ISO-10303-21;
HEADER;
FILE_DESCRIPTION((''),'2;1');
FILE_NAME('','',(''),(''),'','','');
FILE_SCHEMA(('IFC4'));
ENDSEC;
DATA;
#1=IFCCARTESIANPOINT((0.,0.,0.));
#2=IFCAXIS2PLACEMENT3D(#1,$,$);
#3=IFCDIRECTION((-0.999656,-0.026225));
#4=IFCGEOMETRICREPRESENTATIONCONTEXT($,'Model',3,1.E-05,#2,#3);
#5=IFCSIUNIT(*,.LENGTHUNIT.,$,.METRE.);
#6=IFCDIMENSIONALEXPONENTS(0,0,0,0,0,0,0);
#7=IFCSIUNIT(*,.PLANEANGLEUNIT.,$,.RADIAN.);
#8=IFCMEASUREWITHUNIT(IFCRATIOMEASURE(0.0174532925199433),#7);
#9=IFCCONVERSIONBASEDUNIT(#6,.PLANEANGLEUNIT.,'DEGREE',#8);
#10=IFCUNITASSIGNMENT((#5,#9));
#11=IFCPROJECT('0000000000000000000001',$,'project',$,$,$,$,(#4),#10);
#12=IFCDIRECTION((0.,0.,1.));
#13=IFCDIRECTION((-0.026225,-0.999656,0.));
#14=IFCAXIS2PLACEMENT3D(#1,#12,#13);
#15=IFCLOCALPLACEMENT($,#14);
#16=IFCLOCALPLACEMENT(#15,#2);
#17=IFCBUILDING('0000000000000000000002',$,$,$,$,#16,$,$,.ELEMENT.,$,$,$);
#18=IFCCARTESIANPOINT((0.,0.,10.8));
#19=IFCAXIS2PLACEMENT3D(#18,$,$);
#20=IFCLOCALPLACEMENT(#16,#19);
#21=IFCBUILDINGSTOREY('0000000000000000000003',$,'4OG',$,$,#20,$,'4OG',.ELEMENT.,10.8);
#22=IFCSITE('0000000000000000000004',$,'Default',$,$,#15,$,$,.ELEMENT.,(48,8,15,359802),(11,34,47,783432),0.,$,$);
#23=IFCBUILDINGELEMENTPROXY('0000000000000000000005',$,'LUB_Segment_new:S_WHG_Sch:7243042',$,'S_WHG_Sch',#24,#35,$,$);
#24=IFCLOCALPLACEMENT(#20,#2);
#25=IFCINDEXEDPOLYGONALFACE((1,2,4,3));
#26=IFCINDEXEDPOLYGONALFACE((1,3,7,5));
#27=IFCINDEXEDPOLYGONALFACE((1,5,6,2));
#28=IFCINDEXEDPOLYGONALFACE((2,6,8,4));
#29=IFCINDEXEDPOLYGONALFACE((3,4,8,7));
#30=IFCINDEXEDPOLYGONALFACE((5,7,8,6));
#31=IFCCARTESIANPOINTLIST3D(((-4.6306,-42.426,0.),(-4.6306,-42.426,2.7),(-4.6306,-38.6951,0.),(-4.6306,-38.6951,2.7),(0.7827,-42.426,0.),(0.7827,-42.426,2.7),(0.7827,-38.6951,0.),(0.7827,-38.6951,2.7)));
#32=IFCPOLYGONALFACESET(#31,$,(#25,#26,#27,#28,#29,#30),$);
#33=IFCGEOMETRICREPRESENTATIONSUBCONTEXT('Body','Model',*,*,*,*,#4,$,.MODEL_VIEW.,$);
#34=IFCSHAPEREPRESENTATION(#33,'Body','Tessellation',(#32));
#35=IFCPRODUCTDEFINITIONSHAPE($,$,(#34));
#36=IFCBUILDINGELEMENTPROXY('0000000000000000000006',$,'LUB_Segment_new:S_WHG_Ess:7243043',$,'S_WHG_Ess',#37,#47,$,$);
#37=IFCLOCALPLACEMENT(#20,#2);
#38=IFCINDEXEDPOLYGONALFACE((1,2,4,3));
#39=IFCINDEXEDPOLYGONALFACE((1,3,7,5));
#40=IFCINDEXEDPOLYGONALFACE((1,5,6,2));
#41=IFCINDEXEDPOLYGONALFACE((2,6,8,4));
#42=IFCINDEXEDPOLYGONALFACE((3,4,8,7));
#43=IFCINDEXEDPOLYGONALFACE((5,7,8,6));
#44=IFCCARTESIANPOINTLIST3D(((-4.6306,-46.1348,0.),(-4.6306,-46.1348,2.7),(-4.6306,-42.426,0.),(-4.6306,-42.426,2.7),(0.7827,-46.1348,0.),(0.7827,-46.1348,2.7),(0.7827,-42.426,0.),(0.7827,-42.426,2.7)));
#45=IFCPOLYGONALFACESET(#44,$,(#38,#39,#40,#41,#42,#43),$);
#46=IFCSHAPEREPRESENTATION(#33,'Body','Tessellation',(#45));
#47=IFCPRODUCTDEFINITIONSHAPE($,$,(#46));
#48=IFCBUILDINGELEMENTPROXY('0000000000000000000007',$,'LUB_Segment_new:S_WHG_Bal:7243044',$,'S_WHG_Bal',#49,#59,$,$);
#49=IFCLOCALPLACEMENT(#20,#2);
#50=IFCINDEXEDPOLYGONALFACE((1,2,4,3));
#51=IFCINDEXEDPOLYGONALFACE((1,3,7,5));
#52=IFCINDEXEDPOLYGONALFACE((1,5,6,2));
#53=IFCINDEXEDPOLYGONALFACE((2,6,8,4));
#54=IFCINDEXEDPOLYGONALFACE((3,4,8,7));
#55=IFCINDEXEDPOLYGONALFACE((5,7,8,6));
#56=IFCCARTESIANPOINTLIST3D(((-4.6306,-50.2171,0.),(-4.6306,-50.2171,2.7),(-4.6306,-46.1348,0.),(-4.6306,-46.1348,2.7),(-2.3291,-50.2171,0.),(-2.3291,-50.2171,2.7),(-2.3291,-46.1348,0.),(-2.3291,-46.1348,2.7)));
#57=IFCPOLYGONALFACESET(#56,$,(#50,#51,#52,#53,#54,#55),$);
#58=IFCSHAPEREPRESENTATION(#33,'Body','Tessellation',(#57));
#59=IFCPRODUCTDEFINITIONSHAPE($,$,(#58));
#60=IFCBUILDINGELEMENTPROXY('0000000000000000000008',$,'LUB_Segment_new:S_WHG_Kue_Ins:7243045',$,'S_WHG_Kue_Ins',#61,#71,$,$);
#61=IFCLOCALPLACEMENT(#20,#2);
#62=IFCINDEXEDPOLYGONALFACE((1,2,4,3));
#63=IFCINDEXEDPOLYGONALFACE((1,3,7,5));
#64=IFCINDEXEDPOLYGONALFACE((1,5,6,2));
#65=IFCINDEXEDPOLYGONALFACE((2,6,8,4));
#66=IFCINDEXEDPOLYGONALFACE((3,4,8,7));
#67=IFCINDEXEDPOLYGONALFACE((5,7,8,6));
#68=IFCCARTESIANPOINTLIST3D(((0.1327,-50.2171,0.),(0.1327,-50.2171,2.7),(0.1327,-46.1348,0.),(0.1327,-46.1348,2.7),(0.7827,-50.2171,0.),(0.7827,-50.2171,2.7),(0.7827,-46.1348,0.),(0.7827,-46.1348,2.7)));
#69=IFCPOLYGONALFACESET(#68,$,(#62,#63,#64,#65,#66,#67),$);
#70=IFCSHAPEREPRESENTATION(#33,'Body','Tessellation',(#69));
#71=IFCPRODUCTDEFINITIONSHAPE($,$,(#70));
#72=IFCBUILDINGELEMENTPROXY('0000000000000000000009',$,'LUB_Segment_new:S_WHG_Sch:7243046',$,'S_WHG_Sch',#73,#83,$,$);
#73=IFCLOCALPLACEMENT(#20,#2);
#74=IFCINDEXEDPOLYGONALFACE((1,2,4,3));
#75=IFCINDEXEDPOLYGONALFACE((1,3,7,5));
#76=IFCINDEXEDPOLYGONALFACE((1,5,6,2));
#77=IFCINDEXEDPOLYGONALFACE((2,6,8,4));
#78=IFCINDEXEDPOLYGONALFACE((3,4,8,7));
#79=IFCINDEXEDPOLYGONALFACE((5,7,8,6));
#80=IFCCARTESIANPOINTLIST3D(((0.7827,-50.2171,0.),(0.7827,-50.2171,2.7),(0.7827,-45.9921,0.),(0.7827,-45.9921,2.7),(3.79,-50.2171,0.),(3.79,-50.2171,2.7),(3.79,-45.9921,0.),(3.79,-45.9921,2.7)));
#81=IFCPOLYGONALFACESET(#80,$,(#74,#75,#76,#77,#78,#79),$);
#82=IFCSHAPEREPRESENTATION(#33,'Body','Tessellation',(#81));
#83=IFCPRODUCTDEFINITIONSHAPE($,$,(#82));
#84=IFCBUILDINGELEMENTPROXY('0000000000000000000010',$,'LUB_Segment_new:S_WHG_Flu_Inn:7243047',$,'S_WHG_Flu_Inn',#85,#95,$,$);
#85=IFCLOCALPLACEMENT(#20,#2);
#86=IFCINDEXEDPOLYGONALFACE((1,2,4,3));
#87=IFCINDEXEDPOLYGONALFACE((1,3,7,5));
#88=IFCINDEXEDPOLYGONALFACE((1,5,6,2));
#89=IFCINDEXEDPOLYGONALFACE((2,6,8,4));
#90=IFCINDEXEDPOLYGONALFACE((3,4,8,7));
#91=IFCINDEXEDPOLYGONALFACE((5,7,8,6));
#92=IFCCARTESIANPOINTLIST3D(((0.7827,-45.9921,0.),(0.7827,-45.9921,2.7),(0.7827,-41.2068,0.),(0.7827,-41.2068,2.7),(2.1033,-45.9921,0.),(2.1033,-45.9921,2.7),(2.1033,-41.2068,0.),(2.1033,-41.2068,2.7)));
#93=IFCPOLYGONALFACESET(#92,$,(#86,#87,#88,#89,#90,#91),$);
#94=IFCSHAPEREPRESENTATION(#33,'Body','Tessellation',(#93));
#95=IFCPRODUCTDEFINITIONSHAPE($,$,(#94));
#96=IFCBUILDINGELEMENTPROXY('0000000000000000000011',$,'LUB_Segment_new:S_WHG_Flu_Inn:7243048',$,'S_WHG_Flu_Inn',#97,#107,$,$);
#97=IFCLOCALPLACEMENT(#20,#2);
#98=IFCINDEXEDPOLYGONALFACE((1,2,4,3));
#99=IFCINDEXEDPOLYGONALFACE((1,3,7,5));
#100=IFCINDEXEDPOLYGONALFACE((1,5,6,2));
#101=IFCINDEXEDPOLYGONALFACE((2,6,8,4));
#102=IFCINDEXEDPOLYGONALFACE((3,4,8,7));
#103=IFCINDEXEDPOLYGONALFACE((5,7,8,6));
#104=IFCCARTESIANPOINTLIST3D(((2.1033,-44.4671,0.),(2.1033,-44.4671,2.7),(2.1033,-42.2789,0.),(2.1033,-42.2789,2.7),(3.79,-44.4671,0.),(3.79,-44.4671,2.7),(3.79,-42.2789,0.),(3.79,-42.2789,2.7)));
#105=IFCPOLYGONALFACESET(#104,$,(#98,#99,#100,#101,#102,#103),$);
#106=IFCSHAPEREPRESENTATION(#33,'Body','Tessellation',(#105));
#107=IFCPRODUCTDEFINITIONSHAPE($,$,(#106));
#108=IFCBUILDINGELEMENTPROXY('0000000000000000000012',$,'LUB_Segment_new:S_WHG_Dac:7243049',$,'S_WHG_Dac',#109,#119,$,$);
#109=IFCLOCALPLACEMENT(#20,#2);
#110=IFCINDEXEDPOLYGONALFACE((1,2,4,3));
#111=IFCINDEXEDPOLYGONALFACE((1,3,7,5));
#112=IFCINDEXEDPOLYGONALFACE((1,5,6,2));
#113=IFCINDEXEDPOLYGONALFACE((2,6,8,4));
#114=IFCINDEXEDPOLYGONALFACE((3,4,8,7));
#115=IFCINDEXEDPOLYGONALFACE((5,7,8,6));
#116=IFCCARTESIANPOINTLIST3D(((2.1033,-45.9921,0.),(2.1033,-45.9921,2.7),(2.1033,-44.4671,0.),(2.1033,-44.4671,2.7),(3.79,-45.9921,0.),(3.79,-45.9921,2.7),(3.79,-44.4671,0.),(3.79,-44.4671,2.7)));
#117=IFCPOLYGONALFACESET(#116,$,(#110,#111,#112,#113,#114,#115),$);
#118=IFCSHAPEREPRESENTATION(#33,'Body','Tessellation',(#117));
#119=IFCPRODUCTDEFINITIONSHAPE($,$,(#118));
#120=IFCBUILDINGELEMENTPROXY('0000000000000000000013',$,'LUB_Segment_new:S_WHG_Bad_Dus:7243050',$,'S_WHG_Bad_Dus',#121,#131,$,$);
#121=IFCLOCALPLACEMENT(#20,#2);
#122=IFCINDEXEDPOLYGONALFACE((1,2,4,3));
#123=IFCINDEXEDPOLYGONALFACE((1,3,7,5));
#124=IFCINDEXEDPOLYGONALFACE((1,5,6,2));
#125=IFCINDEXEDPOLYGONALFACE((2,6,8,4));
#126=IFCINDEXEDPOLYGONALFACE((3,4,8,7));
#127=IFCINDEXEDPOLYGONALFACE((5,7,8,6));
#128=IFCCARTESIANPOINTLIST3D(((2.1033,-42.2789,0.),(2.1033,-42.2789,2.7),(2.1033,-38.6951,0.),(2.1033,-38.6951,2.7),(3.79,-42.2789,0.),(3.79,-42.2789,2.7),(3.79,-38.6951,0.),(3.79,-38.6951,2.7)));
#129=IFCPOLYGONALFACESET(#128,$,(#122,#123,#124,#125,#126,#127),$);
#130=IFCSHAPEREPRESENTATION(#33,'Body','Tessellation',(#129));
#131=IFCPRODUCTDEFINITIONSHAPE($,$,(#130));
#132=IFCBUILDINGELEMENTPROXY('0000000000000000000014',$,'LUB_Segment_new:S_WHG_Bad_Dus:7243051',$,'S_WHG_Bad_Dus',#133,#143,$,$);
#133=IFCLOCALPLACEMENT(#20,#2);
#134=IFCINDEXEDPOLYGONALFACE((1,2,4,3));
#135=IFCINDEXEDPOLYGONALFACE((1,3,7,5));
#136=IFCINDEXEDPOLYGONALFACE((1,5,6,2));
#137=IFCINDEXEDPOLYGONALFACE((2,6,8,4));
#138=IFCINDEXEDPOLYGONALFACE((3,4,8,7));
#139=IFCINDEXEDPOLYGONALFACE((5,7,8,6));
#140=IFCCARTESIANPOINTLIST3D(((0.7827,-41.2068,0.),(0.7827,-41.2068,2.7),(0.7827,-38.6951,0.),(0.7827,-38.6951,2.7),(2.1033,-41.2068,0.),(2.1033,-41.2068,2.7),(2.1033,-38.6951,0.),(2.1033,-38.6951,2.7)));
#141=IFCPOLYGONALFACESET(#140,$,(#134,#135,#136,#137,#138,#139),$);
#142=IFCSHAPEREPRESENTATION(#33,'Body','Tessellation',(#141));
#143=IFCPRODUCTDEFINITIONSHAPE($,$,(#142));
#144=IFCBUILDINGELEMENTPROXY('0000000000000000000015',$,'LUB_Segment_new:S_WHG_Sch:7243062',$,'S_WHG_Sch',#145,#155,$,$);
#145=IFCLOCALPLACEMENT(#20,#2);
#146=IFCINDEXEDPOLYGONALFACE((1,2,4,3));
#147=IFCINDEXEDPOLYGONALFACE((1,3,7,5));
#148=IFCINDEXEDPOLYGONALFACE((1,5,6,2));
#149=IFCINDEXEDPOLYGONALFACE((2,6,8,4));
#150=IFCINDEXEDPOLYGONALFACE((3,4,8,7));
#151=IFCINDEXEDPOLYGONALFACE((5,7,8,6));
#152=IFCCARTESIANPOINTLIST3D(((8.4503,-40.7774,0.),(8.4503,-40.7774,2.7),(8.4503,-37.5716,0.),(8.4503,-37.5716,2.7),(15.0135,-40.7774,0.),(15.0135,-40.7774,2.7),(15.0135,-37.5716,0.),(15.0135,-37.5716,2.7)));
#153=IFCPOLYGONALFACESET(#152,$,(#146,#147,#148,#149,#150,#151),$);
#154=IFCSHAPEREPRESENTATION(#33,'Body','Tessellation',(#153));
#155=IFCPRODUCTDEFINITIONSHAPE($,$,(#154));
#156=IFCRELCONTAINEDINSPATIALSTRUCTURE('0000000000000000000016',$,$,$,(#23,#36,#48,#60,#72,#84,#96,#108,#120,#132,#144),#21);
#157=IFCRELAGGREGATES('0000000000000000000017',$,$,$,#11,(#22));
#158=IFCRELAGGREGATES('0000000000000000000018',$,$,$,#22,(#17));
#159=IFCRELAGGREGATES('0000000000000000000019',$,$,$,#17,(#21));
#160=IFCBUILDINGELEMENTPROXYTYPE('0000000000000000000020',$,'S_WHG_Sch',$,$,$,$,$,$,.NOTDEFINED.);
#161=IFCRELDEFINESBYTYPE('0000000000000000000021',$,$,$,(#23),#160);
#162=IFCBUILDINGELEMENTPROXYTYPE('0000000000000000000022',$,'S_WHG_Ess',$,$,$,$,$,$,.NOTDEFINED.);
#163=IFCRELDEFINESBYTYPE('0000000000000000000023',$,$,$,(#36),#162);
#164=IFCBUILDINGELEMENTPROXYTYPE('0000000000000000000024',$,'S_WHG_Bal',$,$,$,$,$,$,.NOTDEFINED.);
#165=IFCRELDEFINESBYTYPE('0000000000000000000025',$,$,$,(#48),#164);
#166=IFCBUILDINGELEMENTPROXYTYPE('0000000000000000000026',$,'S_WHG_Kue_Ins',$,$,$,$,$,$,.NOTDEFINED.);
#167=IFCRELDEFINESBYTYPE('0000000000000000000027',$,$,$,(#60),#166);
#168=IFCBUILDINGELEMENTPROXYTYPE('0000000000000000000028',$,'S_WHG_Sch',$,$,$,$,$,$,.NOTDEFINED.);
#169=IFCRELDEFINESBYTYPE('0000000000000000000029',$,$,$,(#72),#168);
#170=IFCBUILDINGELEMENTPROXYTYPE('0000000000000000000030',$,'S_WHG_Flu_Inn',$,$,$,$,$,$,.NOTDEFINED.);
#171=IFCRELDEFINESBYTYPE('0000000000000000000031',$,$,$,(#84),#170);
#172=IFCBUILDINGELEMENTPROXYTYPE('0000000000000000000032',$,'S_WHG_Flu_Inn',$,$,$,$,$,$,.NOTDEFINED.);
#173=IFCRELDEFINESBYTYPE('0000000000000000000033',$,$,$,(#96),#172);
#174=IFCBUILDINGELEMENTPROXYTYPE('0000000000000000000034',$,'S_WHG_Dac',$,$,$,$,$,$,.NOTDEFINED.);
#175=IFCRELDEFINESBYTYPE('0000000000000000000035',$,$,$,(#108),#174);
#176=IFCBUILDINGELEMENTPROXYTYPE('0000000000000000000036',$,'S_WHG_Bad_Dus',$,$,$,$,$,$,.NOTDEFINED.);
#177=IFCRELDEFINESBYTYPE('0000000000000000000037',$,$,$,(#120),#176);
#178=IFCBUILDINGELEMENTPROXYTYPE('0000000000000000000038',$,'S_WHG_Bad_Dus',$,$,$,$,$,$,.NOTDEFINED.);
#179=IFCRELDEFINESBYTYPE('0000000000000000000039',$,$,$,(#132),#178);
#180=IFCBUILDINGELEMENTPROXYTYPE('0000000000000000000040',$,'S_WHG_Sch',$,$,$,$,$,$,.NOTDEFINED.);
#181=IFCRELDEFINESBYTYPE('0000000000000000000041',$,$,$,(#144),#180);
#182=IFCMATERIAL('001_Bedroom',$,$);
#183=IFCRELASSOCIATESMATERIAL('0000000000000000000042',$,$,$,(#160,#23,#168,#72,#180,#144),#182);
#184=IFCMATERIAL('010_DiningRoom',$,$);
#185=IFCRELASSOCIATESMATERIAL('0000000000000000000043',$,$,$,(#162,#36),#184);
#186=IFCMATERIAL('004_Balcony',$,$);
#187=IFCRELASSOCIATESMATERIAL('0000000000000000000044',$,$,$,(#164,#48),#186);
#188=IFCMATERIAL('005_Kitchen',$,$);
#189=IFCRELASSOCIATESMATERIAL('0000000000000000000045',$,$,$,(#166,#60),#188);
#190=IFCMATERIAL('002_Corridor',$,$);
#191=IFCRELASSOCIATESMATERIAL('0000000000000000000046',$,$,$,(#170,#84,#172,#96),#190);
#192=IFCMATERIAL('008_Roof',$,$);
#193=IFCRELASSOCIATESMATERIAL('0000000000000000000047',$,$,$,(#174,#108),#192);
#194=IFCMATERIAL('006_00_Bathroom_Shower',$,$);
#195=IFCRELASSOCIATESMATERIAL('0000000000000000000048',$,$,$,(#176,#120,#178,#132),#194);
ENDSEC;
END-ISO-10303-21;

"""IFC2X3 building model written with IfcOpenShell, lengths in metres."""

from ifc_helpers import new_model, entity, si_unit, converted_unit, direction, frame, frame_2d, origin, origin_2d_with_axis, place, context, subcontext, project, spatial, rectangle, extrude, source, transform, mapped, material, type_object, type_shapes, element, save


model = new_model("IFC2X3")

# Units and contexts
model_context = context("Model", 3, precision=1e-05, world=origin(), true_north=direction((-0.999656, -0.026225)))
body_context = subcontext(model_context, "Body", "Model", "MODEL_VIEW")
ifc_project = project(units=[si_unit("LENGTHUNIT", "METRE"), converted_unit("PLANEANGLEUNIT", "DEGREE", entity("IfcRatioMeasure", 0.0174532925199433), si_unit("PLANEANGLEUNIT", "RADIAN"), dimensions=[0, 0, 0, 0, 0, 0, 0])], contexts=[model_context])

# Site, building, storey
site_placement = place(None, frame((0.0, 0.0, 0.0), z_axis=(0.0, 0.0, 1.0), x_axis=(-0.026225, -0.999656, 0.0)))
site = spatial("IfcSite", under=ifc_project, at=site_placement, Name="Default", CompositionType="ELEMENT", RefLatitude=(48, 8, 15, 359802), RefLongitude=(11, 34, 47, 783432), RefElevation=0.0)
building_placement = place(site_placement, origin())
building = spatial("IfcBuilding", under=site, at=building_placement, CompositionType="ELEMENT")
storey_placement = place(building_placement, frame((0.0, 0.0, 10.8)))
storey = spatial("IfcBuildingStorey", under=building, at=storey_placement, Name="4OG", LongName="4OG", CompositionType="ELEMENT", Elevation=10.8)

# Building element proxies
ifc_material_1 = material(Name="001_Bedroom")
building_element_proxy_type_1 = type_object("IfcBuildingElementProxyType", Name="S_WHG_Sch", PredefinedType="NOTDEFINED", material=ifc_material_1)
shared_shape_1 = source(origin(), body_context, "Body", "SweptSolid", [
    extrude(rectangle(XDim=5.4132, YDim=3.7309, at=origin_2d_with_axis()), frame((0.0, 0.0, 0.0), z_axis=(0.0, 0.0, 1.0), x_axis=(-1.0, 0.0, 0.0)), (0.0, 0.0, 1.0), 2.7),
])
type_shapes(building_element_proxy_type_1, [shared_shape_1])
proxy_1_placement = place(storey_placement, frame((-1.924, -40.5605, 0.0)))
element("IfcBuildingElementProxy", 1, at=proxy_1_placement, inside=storey, type_object=building_element_proxy_type_1, material=ifc_material_1, Name="LUB_Segment_new:S_WHG_Sch:7243042", ObjectType="S_WHG_Sch", context=body_context, shape_type="MappedRepresentation", body=[
    mapped(shared_shape_1, transform((0.0, 0.0, 0.0), scale=1.0)),
])
ifc_material_2 = material(Name="010_DiningRoom")
building_element_proxy_type_2 = type_object("IfcBuildingElementProxyType", Name="S_WHG_Ess", PredefinedType="NOTDEFINED", material=ifc_material_2)
shared_shape_2 = source(origin(), body_context, "Body", "SweptSolid", [
    extrude(rectangle(XDim=5.4132, YDim=3.7088, at=origin_2d_with_axis()), frame((0.0, 0.0, 0.0), z_axis=(0.0, 0.0, 1.0), x_axis=(-1.0, 0.0, 0.0)), (0.0, 0.0, 1.0), 2.7),
])
type_shapes(building_element_proxy_type_2, [shared_shape_2])
proxy_2_placement = place(storey_placement, frame((-1.924, -44.2804, 0.0)))
element("IfcBuildingElementProxy", 2, at=proxy_2_placement, inside=storey, type_object=building_element_proxy_type_2, material=ifc_material_2, Name="LUB_Segment_new:S_WHG_Ess:7243043", ObjectType="S_WHG_Ess", context=body_context, shape_type="MappedRepresentation", body=[
    mapped(shared_shape_2, transform((0.0, 0.0, 0.0), scale=1.0)),
])
ifc_material_3 = material(Name="004_Balcony")
building_element_proxy_type_3 = type_object("IfcBuildingElementProxyType", Name="S_WHG_Bal", PredefinedType="NOTDEFINED", material=ifc_material_3)
shared_shape_3 = source(origin(), body_context, "Body", "SweptSolid", [
    extrude(rectangle(XDim=4.0824, YDim=2.3015, at=origin_2d_with_axis()), frame((0.0, 0.0, 0.0), z_axis=(0.0, 0.0, 1.0), x_axis=(0.0, 1.0, 0.0)), (0.0, 0.0, 1.0), 2.7),
])
type_shapes(building_element_proxy_type_3, [shared_shape_3])
proxy_3_placement = place(storey_placement, frame((-3.4798, -48.176, 0.0)))
element("IfcBuildingElementProxy", 3, at=proxy_3_placement, inside=storey, type_object=building_element_proxy_type_3, material=ifc_material_3, Name="LUB_Segment_new:S_WHG_Bal:7243044", ObjectType="S_WHG_Bal", context=body_context, shape_type="MappedRepresentation", body=[
    mapped(shared_shape_3, transform((0.0, 0.0, 0.0), scale=1.0)),
])
ifc_material_4 = material(Name="005_Kitchen")
building_element_proxy_type_4 = type_object("IfcBuildingElementProxyType", Name="S_WHG_Kue_Ins", PredefinedType="NOTDEFINED", material=ifc_material_4)
shared_shape_4 = source(origin(), body_context, "Body", "SweptSolid", [
    extrude(rectangle(XDim=4.0824, YDim=0.65, at=origin_2d_with_axis()), frame((0.0, 0.0, 0.0), z_axis=(0.0, 0.0, 1.0), x_axis=(0.0, 1.0, 0.0)), (0.0, 0.0, 1.0), 2.7),
])
type_shapes(building_element_proxy_type_4, [shared_shape_4])
proxy_4_placement = place(storey_placement, frame((0.4577, -48.176, 0.0)))
element("IfcBuildingElementProxy", 4, at=proxy_4_placement, inside=storey, type_object=building_element_proxy_type_4, material=ifc_material_4, Name="LUB_Segment_new:S_WHG_Kue_Ins:7243045", ObjectType="S_WHG_Kue_Ins", context=body_context, shape_type="MappedRepresentation", body=[
    mapped(shared_shape_4, transform((0.0, 0.0, 0.0), scale=1.0)),
])
building_element_proxy_type_5 = type_object("IfcBuildingElementProxyType", Name="S_WHG_Sch", PredefinedType="NOTDEFINED", material=ifc_material_1)
shared_shape_5 = source(origin(), body_context, "Body", "SweptSolid", [
    extrude(rectangle(XDim=4.225, YDim=3.0074, at=origin_2d_with_axis()), frame((0.0, 0.0, 0.0), z_axis=(0.0, 0.0, 1.0), x_axis=(0.0, 1.0, 0.0)), (0.0, 0.0, 1.0), 2.7),
])
type_shapes(building_element_proxy_type_5, [shared_shape_5])
proxy_5_placement = place(storey_placement, frame((2.2863, -48.1046, 0.0)))
element("IfcBuildingElementProxy", 5, at=proxy_5_placement, inside=storey, type_object=building_element_proxy_type_5, material=ifc_material_1, Name="LUB_Segment_new:S_WHG_Sch:7243046", ObjectType="S_WHG_Sch", context=body_context, shape_type="MappedRepresentation", body=[
    mapped(shared_shape_5, transform((0.0, 0.0, 0.0), scale=1.0)),
])
ifc_material_5 = material(Name="002_Corridor")
building_element_proxy_type_6 = type_object("IfcBuildingElementProxyType", Name="S_WHG_Flu_Inn", PredefinedType="NOTDEFINED", material=ifc_material_5)
shared_shape_6 = source(origin(), body_context, "Body", "SweptSolid", [
    extrude(rectangle(XDim=4.7853, YDim=1.3206, at=origin_2d_with_axis()), frame((0.0, 0.0, 0.0), z_axis=(0.0, 0.0, 1.0), x_axis=(0.0, 1.0, 0.0)), (0.0, 0.0, 1.0), 2.7),
])
type_shapes(building_element_proxy_type_6, [shared_shape_6])
proxy_6_placement = place(storey_placement, frame((1.443, -43.5995, 0.0)))
element("IfcBuildingElementProxy", 6, at=proxy_6_placement, inside=storey, type_object=building_element_proxy_type_6, material=ifc_material_5, Name="LUB_Segment_new:S_WHG_Flu_Inn:7243047", ObjectType="S_WHG_Flu_Inn", context=body_context, shape_type="MappedRepresentation", body=[
    mapped(shared_shape_6, transform((0.0, 0.0, 0.0), scale=1.0)),
])
building_element_proxy_type_7 = type_object("IfcBuildingElementProxyType", Name="S_WHG_Flu_Inn", PredefinedType="NOTDEFINED", material=ifc_material_5)
shared_shape_7 = source(origin(), body_context, "Body", "SweptSolid", [
    extrude(rectangle(XDim=2.1882, YDim=1.6868, at=origin_2d_with_axis()), frame((0.0, 0.0, 0.0), z_axis=(0.0, 0.0, 1.0), x_axis=(0.0, 1.0, 0.0)), (0.0, 0.0, 1.0), 2.7),
])
type_shapes(building_element_proxy_type_7, [shared_shape_7])
proxy_7_placement = place(storey_placement, frame((2.9466, -43.373, 0.0)))
element("IfcBuildingElementProxy", 7, at=proxy_7_placement, inside=storey, type_object=building_element_proxy_type_7, material=ifc_material_5, Name="LUB_Segment_new:S_WHG_Flu_Inn:7243048", ObjectType="S_WHG_Flu_Inn", context=body_context, shape_type="MappedRepresentation", body=[
    mapped(shared_shape_7, transform((0.0, 0.0, 0.0), scale=1.0)),
])
ifc_material_6 = material(Name="008_Roof")
building_element_proxy_type_8 = type_object("IfcBuildingElementProxyType", Name="S_WHG_Dac", PredefinedType="NOTDEFINED", material=ifc_material_6)
shared_shape_8 = source(origin(), body_context, "Body", "SweptSolid", [
    extrude(rectangle(XDim=1.525, YDim=1.6868, at=origin_2d_with_axis()), frame((0.0, 0.0, 0.0), z_axis=(0.0, 0.0, 1.0), x_axis=(0.0, 1.0, 0.0)), (0.0, 0.0, 1.0), 2.7),
])
type_shapes(building_element_proxy_type_8, [shared_shape_8])
proxy_8_placement = place(storey_placement, frame((2.9466, -45.2296, 0.0)))
element("IfcBuildingElementProxy", 8, at=proxy_8_placement, inside=storey, type_object=building_element_proxy_type_8, material=ifc_material_6, Name="LUB_Segment_new:S_WHG_Dac:7243049", ObjectType="S_WHG_Dac", context=body_context, shape_type="MappedRepresentation", body=[
    mapped(shared_shape_8, transform((0.0, 0.0, 0.0), scale=1.0)),
])
ifc_material_7 = material(Name="006_00_Bathroom_Shower")
building_element_proxy_type_9 = type_object("IfcBuildingElementProxyType", Name="S_WHG_Bad_Dus", PredefinedType="NOTDEFINED", material=ifc_material_7)
shared_shape_9 = source(origin(), body_context, "Body", "SweptSolid", [
    extrude(rectangle(XDim=3.5838, YDim=1.6868, at=origin_2d_with_axis()), frame((0.0, 0.0, 0.0), z_axis=(0.0, 0.0, 1.0), x_axis=(0.0, 1.0, 0.0)), (0.0, 0.0, 1.0), 2.7),
])
type_shapes(building_element_proxy_type_9, [shared_shape_9])
proxy_9_placement = place(storey_placement, frame((2.9466, -40.487, 0.0)))
element("IfcBuildingElementProxy", 9, at=proxy_9_placement, inside=storey, type_object=building_element_proxy_type_9, material=ifc_material_7, Name="LUB_Segment_new:S_WHG_Bad_Dus:7243050", ObjectType="S_WHG_Bad_Dus", context=body_context, shape_type="MappedRepresentation", body=[
    mapped(shared_shape_9, transform((0.0, 0.0, 0.0), scale=1.0)),
])
building_element_proxy_type_10 = type_object("IfcBuildingElementProxyType", Name="S_WHG_Bad_Dus", PredefinedType="NOTDEFINED", material=ifc_material_7)
shared_shape_10 = source(origin(), body_context, "Body", "SweptSolid", [
    extrude(rectangle(XDim=2.5118, YDim=1.3206, at=frame_2d((0.0, 0.0), x_axis=(1.0, 0.0))), frame((0.0, 0.0, 0.0), z_axis=(0.0, 0.0, 1.0), x_axis=(0.0, 1.0, 0.0)), (0.0, 0.0, 1.0), 2.7),
])
type_shapes(building_element_proxy_type_10, [shared_shape_10])
proxy_10_placement = place(storey_placement, frame((1.443, -39.951, 0.0)))
element("IfcBuildingElementProxy", 10, at=proxy_10_placement, inside=storey, type_object=building_element_proxy_type_10, material=ifc_material_7, Name="LUB_Segment_new:S_WHG_Bad_Dus:7243051", ObjectType="S_WHG_Bad_Dus", context=body_context, shape_type="MappedRepresentation", body=[
    mapped(shared_shape_10, transform((0.0, 0.0, 0.0), scale=1.0)),
])
building_element_proxy_type_11 = type_object("IfcBuildingElementProxyType", Name="S_WHG_Sch", PredefinedType="NOTDEFINED", material=ifc_material_1)
shared_shape_11 = source(origin(), body_context, "Body", "SweptSolid", [
    extrude(rectangle(XDim=6.5632, YDim=3.2059, at=origin_2d_with_axis()), frame((0.0, 0.0, 0.0), z_axis=(0.0, 0.0, 1.0), x_axis=(-1.0, 0.0, 0.0)), (0.0, 0.0, 1.0), 2.7),
])
type_shapes(building_element_proxy_type_11, [shared_shape_11])
proxy_11_placement = place(storey_placement, frame((11.7319, -39.1745, 0.0)))
element("IfcBuildingElementProxy", 11, at=proxy_11_placement, inside=storey, type_object=building_element_proxy_type_11, material=ifc_material_1, Name="LUB_Segment_new:S_WHG_Sch:7243062", ObjectType="S_WHG_Sch", context=body_context, shape_type="MappedRepresentation", body=[
    mapped(shared_shape_11, transform((0.0, 0.0, 0.0), scale=1.0)),
])

save(model, "model.ifc")
